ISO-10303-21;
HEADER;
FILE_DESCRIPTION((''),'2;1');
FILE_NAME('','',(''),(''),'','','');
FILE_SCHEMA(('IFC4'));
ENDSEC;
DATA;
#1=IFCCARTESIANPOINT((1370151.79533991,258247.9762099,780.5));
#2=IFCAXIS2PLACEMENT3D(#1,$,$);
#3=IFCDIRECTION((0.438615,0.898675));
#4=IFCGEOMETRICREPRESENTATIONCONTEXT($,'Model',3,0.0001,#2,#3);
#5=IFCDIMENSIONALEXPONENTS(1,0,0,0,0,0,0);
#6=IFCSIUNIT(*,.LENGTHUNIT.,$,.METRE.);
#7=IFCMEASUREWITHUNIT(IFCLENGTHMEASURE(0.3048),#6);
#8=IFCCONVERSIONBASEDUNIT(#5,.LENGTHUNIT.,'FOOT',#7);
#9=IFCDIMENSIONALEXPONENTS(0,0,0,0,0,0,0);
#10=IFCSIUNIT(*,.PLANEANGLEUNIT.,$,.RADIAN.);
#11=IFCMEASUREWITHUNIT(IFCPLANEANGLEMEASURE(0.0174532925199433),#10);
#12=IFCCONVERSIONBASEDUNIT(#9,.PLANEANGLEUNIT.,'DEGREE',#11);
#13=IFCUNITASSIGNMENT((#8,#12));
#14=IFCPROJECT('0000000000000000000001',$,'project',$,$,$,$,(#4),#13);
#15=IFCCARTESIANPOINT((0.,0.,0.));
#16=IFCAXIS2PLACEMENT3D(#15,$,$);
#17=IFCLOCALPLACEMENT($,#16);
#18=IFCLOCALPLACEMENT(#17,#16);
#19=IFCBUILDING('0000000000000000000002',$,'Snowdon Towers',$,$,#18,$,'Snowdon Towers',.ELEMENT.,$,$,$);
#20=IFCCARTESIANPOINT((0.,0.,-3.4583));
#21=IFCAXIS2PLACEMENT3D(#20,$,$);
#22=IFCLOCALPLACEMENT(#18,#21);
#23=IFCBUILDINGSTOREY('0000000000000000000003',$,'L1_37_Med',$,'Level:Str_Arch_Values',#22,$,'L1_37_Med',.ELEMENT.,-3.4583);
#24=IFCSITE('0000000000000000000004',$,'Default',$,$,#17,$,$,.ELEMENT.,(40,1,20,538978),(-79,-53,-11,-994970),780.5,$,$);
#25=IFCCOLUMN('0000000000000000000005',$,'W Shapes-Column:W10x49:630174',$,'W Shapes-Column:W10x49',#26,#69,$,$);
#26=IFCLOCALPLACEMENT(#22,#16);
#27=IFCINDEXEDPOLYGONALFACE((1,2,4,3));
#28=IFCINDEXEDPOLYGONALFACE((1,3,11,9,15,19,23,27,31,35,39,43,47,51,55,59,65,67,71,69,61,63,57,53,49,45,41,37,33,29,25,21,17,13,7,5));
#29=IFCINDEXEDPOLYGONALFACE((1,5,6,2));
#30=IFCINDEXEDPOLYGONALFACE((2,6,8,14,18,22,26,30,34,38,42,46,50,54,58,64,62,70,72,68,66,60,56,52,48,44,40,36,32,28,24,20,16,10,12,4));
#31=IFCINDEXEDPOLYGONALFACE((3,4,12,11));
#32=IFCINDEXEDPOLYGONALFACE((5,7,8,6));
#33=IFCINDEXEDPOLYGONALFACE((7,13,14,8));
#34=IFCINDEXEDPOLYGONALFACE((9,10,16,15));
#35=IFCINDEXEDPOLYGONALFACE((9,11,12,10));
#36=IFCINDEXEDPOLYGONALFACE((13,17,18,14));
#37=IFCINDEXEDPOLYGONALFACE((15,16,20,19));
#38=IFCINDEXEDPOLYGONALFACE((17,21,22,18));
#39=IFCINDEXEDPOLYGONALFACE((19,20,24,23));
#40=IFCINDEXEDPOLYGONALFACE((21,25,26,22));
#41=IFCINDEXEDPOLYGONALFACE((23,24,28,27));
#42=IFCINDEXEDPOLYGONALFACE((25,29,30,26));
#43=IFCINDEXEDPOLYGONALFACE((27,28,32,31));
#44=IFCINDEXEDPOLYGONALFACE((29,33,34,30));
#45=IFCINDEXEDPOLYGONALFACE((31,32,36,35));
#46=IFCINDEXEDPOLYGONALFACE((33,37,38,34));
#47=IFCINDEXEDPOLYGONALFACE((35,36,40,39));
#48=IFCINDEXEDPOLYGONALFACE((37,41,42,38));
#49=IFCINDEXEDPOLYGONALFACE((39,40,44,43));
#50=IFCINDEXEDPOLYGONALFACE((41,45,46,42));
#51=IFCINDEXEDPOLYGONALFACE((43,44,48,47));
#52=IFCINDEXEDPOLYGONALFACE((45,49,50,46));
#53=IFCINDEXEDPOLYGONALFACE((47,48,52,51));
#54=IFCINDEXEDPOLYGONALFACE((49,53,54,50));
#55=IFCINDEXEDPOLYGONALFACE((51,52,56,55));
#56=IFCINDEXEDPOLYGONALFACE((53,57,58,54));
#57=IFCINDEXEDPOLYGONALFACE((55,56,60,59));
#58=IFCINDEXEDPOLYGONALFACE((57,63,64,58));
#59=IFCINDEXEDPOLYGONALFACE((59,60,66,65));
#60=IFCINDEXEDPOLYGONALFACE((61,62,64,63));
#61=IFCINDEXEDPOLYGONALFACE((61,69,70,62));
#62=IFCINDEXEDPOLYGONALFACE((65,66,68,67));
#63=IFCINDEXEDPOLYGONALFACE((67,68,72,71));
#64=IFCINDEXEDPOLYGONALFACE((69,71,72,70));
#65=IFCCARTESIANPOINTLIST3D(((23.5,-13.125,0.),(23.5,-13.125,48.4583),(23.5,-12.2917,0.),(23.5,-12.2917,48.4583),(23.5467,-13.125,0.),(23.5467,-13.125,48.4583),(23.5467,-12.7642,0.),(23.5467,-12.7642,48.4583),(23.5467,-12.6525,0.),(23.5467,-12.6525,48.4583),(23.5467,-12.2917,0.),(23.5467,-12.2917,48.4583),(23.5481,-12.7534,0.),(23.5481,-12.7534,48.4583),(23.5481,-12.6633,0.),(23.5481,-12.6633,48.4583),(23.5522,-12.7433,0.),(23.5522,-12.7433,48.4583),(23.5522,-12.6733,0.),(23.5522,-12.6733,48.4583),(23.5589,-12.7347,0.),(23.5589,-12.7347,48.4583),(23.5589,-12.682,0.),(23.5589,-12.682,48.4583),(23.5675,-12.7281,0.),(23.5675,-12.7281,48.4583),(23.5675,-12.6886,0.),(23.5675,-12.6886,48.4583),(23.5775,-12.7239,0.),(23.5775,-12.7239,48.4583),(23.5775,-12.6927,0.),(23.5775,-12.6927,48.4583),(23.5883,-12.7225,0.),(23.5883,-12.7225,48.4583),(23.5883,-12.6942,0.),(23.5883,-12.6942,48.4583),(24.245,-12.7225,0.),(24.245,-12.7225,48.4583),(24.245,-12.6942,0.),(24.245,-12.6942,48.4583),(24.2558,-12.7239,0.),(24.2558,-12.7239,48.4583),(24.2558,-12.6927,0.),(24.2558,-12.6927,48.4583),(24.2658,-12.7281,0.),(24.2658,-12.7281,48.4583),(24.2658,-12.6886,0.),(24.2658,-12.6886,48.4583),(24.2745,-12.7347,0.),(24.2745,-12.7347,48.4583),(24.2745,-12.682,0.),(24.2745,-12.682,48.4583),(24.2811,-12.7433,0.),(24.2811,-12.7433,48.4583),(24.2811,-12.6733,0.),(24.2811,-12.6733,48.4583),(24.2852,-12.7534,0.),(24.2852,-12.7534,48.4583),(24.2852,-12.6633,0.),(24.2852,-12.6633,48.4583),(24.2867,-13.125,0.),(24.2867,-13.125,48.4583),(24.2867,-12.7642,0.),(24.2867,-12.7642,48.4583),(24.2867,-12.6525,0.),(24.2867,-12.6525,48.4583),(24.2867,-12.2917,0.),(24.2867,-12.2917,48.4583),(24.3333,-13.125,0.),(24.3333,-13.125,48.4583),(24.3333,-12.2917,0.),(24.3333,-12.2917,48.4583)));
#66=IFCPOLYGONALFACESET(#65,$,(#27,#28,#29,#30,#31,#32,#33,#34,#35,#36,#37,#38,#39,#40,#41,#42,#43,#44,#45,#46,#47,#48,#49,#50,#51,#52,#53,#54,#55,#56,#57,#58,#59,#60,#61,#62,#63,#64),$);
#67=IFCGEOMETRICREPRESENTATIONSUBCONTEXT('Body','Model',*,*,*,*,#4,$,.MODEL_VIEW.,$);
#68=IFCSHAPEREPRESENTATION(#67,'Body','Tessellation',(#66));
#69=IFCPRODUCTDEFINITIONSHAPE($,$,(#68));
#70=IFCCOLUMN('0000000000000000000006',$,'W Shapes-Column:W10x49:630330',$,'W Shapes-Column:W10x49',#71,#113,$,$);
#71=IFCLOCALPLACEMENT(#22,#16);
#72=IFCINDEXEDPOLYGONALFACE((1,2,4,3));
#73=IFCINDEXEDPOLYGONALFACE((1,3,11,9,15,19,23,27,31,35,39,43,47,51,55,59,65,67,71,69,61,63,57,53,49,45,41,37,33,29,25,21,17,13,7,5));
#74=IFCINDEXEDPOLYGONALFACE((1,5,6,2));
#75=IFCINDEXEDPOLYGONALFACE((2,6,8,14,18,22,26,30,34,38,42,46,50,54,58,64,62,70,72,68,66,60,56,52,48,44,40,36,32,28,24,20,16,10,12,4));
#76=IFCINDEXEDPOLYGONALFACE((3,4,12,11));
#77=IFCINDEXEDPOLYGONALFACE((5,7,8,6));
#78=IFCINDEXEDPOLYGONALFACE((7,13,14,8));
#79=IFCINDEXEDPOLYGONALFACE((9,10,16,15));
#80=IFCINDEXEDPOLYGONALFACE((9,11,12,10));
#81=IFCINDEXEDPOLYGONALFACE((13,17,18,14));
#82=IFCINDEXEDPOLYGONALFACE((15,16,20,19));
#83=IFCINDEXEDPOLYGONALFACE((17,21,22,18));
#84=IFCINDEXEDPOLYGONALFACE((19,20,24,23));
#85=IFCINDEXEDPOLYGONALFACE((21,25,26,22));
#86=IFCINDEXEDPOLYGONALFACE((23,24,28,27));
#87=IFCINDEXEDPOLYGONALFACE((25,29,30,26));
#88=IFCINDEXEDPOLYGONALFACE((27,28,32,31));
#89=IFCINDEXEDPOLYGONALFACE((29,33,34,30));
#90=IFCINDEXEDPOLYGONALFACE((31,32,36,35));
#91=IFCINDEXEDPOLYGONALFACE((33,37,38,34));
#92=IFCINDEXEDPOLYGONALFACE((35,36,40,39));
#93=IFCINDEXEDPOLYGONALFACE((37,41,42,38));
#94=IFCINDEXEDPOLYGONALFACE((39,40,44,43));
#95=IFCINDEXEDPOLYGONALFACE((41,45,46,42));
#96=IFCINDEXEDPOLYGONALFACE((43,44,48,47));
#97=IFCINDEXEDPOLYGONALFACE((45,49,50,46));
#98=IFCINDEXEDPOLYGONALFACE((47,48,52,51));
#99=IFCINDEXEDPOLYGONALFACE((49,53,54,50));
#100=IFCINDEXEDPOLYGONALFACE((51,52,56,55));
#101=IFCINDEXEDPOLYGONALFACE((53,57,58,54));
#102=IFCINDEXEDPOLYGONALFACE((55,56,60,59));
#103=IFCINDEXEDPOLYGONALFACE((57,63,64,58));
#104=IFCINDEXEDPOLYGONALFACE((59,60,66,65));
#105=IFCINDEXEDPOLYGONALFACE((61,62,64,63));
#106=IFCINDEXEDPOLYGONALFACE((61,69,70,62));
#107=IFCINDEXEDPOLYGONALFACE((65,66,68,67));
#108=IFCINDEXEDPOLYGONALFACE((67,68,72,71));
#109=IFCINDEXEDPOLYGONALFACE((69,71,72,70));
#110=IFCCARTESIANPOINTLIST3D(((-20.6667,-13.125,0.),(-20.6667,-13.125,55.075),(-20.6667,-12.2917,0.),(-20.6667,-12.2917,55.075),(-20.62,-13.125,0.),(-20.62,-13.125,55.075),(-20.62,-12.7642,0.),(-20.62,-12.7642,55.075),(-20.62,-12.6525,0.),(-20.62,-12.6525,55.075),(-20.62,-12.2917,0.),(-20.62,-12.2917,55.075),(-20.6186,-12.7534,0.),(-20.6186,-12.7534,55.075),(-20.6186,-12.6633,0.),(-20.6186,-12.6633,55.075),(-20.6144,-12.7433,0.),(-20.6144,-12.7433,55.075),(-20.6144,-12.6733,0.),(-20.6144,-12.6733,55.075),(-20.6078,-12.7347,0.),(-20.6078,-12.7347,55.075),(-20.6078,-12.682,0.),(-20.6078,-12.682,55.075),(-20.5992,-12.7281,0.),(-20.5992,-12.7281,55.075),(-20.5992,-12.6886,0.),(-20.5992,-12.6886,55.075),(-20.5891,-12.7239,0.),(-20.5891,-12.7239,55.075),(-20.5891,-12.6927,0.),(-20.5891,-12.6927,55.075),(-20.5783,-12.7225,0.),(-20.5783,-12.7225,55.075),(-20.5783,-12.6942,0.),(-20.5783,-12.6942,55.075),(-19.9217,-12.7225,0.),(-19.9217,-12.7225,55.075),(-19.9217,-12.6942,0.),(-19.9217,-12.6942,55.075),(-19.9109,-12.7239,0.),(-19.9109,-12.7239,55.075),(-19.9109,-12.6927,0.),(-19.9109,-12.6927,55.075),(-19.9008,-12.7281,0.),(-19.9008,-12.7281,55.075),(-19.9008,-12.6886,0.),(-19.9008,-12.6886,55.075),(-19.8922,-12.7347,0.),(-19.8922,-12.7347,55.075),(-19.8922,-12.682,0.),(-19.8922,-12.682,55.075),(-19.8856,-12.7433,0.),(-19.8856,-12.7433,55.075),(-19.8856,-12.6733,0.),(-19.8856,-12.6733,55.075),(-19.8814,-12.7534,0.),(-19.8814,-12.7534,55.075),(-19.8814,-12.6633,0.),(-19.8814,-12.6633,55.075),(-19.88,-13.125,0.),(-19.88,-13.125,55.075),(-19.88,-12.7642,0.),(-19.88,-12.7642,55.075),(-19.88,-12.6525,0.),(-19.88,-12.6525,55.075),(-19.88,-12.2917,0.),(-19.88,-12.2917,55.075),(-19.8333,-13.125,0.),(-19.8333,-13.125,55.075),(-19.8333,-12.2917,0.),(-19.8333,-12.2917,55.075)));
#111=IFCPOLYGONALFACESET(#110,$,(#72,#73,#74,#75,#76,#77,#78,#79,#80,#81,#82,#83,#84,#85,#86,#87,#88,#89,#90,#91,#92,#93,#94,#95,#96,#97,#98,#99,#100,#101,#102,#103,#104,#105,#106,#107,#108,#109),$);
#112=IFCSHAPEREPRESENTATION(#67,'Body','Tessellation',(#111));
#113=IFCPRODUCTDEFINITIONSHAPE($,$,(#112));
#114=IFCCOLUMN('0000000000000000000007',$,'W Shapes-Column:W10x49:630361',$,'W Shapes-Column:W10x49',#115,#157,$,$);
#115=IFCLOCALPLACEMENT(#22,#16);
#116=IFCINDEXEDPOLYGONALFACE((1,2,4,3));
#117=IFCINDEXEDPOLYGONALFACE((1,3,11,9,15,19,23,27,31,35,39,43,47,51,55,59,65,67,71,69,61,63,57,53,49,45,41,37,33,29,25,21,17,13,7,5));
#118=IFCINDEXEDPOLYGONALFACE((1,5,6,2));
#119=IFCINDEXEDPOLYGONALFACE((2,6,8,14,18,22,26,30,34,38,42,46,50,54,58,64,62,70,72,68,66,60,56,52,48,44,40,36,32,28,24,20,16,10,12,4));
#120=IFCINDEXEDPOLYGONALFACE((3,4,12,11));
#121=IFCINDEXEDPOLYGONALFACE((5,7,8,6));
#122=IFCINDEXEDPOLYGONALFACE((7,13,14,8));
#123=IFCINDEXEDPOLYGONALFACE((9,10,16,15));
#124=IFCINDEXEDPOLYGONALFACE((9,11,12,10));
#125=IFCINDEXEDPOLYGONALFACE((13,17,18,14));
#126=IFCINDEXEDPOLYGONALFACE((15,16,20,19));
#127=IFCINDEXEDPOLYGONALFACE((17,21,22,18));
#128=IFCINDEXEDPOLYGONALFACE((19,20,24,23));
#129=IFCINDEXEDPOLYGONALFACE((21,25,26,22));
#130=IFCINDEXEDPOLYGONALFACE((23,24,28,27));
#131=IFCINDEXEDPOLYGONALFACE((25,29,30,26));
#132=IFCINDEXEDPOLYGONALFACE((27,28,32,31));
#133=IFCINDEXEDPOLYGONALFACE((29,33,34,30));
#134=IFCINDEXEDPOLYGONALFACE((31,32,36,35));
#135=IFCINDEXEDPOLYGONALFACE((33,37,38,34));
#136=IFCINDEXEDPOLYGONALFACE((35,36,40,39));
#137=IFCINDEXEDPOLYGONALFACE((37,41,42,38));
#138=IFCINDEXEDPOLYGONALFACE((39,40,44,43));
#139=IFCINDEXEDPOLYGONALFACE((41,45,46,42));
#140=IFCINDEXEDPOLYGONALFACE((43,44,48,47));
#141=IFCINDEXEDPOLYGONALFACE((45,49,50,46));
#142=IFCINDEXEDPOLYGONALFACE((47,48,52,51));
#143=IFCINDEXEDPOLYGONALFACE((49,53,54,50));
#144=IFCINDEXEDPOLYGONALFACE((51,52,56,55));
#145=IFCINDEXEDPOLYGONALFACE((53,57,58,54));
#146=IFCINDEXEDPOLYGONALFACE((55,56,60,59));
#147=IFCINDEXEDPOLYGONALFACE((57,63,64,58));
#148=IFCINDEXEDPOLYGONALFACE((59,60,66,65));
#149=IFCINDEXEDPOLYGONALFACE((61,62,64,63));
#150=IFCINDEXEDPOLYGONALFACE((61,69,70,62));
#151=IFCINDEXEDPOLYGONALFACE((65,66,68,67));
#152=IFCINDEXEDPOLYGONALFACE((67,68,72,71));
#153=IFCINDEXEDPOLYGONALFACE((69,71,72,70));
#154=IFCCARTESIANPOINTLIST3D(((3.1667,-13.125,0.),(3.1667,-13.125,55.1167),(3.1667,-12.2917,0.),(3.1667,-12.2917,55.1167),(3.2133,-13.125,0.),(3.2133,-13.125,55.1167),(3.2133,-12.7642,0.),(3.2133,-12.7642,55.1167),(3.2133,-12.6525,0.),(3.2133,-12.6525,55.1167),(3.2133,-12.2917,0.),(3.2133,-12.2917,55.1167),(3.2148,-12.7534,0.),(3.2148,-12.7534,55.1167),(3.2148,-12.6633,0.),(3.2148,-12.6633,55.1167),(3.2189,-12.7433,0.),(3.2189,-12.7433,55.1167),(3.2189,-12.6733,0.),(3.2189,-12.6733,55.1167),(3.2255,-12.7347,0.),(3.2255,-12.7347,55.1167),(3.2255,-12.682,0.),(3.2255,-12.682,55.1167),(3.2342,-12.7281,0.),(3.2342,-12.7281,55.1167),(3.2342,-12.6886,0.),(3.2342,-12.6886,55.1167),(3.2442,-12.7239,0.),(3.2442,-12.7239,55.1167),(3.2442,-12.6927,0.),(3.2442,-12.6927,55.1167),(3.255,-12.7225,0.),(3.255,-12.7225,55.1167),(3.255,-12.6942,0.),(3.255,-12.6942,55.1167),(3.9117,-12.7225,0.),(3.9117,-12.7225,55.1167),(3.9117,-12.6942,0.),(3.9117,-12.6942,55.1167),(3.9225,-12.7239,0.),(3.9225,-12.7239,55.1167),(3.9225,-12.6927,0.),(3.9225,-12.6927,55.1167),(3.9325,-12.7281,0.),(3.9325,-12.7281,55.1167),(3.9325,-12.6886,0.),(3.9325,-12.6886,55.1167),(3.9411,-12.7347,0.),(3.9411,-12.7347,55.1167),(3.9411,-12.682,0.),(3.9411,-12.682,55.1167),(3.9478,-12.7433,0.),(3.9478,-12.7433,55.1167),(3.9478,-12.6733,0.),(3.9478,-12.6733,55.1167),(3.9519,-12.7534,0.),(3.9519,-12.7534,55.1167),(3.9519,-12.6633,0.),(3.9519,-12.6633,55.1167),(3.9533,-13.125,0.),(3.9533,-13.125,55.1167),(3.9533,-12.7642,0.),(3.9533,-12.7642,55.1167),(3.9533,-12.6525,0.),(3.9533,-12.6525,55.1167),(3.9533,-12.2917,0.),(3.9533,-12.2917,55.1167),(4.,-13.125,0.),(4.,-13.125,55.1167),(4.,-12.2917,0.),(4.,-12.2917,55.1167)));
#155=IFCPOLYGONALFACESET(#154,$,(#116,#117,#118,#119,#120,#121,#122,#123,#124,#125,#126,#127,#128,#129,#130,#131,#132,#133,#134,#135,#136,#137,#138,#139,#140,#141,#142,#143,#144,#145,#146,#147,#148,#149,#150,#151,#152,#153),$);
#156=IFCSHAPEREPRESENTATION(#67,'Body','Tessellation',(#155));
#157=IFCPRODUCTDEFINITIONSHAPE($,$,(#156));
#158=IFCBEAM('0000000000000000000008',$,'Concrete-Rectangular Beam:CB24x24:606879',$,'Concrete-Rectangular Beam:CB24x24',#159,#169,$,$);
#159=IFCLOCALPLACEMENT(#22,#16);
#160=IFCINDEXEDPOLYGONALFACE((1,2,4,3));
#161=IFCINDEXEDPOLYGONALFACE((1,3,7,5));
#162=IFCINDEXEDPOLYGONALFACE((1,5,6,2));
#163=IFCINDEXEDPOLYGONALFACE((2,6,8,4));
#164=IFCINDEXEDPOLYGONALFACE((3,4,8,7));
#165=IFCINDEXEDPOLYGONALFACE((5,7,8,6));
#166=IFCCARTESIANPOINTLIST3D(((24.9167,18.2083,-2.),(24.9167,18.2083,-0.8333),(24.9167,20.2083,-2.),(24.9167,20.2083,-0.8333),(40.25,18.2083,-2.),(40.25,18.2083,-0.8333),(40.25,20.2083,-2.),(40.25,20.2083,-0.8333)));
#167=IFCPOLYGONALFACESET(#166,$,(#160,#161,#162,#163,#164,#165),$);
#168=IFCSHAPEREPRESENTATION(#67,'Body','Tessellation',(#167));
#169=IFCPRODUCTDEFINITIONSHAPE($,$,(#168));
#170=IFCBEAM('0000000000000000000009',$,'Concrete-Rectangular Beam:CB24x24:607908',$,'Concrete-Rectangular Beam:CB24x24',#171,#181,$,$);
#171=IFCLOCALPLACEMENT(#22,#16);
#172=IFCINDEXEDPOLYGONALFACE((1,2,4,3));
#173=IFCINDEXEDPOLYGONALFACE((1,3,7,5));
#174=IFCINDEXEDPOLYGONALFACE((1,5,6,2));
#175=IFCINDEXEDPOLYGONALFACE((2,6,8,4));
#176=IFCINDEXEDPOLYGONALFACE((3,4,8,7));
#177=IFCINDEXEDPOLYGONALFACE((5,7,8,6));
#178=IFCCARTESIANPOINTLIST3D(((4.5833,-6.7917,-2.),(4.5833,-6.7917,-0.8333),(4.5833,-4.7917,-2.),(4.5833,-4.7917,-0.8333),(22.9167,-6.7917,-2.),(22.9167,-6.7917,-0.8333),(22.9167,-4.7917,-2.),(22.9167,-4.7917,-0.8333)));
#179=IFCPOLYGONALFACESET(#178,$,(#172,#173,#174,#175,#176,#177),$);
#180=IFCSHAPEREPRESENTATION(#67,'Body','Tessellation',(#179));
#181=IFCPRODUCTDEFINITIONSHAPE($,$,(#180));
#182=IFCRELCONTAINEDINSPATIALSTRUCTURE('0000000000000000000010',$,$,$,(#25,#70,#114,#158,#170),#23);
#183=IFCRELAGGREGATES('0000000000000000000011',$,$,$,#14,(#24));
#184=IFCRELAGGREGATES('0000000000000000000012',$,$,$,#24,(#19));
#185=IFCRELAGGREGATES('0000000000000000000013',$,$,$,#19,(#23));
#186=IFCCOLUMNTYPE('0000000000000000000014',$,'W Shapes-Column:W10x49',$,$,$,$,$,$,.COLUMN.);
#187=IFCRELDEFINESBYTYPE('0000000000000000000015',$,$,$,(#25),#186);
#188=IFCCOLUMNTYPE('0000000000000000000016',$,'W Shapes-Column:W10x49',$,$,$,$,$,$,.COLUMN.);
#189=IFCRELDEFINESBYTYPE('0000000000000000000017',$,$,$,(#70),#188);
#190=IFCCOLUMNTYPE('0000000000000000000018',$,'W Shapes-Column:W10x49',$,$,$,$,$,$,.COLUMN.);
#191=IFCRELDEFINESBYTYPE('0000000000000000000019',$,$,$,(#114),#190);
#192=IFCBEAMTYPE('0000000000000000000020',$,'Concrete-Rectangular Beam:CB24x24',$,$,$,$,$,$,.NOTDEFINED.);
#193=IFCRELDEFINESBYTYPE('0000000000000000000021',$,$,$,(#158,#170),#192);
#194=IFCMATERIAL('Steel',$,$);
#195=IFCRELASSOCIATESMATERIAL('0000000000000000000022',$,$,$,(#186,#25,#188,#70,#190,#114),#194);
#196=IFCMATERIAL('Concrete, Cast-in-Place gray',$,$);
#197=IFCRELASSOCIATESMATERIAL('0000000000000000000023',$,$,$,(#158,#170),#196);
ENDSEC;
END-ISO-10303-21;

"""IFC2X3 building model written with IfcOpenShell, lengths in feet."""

from ifc_helpers import new_model, entity, si_unit, converted_unit, direction, frame, frame_2d, origin, place, context, subcontext, project, spatial, rectangle, i_section, extrude, source, transform, mapped, material, type_object, type_shapes, element, save


model = new_model("IFC2X3")

# Units and contexts
model_context = context("Model", 3, precision=0.0001, world=frame((1370151.79533991, 258247.9762099, 780.5)), true_north=direction((0.438615, 0.898675)))
body_context = subcontext(model_context, "Body", "Model", "MODEL_VIEW")
ifc_project = project(units=[converted_unit("LENGTHUNIT", "FOOT", entity("IfcLengthMeasure", 0.3048), si_unit("LENGTHUNIT", "METRE"), dimensions=[1, 0, 0, 0, 0, 0, 0]), converted_unit("PLANEANGLEUNIT", "DEGREE", entity("IfcPlaneAngleMeasure", 0.0174532925199433), si_unit("PLANEANGLEUNIT", "RADIAN"), dimensions=[0, 0, 0, 0, 0, 0, 0])], contexts=[model_context])

# Site, building, storey
site_placement = place(None, origin())
site = spatial("IfcSite", under=ifc_project, at=site_placement, Name="Default", CompositionType="ELEMENT", RefLatitude=(40, 1, 20, 538978), RefLongitude=(-79, -53, -11, -994970), RefElevation=780.5)
building_placement = place(site_placement, origin())
building = spatial("IfcBuilding", under=site, at=building_placement, Name="Snowdon Towers", LongName="Snowdon Towers", CompositionType="ELEMENT")
storey_placement = place(building_placement, frame((0.0, 0.0, -3.4583)))
storey = spatial("IfcBuildingStorey", under=building, at=storey_placement, Name="L1_37_Med", ObjectType="Level:Str_Arch_Values", LongName="L1_37_Med", CompositionType="ELEMENT", Elevation=-3.4583)

# Columns
ifc_material_1 = material(Name="Steel")
column_type_1 = type_object("IfcColumnType", Name="W Shapes-Column:W10x49", PredefinedType="COLUMN", material=ifc_material_1)
shared_shape_1 = source(origin(), body_context, "Body", "SweptSolid", [
    extrude(i_section(OverallWidth=0.8333, OverallDepth=0.8333, WebThickness=0.0283, FlangeThickness=0.0467, FilletRadius=0.0417, at=frame_2d((0.0, 0.0), x_axis=(1.0, 0.0))), frame((0.0, 0.0, -3.4583), z_axis=(0.0, 0.0, 1.0), x_axis=(-1.0, 0.0, 0.0)), (0.0, 0.0, 1.0), 48.4583),
])
type_shapes(column_type_1, [shared_shape_1])
column_1_placement = place(storey_placement, frame((23.9167, -12.7083, 3.4583), z_axis=(0.0, 0.0, 1.0), x_axis=(0.0, 1.0, 0.0)))
element("IfcColumn", 1, at=column_1_placement, inside=storey, type_object=column_type_1, material=ifc_material_1, Name="W Shapes-Column:W10x49:630174", ObjectType="W Shapes-Column:W10x49", context=body_context, shape_type="MappedRepresentation", body=[
    mapped(shared_shape_1, transform((0.0, 0.0, 0.0), scale=1.0)),
])
column_type_2 = type_object("IfcColumnType", Name="W Shapes-Column:W10x49", PredefinedType="COLUMN", material=ifc_material_1)
shared_shape_2 = source(origin(), body_context, "Body", "SweptSolid", [
    extrude(i_section(OverallWidth=0.8333, OverallDepth=0.8333, WebThickness=0.0283, FlangeThickness=0.0467, FilletRadius=0.0417, at=frame_2d((0.0, 0.0), x_axis=(1.0, 0.0))), frame((-20.25, -12.7083, -3.4583), z_axis=(0.0, 0.0, 1.0), x_axis=(0.0, -1.0, 0.0)), (0.0, 0.0, 1.0), 55.075),
])
type_shapes(column_type_2, [shared_shape_2])
column_2_placement = place(storey_placement, frame((0.0, 0.0, 3.4583)))
element("IfcColumn", 2, at=column_2_placement, inside=storey, type_object=column_type_2, material=ifc_material_1, Name="W Shapes-Column:W10x49:630330", ObjectType="W Shapes-Column:W10x49", context=body_context, shape_type="MappedRepresentation", body=[
    mapped(shared_shape_2, transform((0.0, 0.0, 0.0), scale=1.0)),
])
column_type_3 = type_object("IfcColumnType", Name="W Shapes-Column:W10x49", PredefinedType="COLUMN", material=ifc_material_1)
shared_shape_3 = source(origin(), body_context, "Body", "SweptSolid", [
    extrude(i_section(OverallWidth=0.8333, OverallDepth=0.8333, WebThickness=0.0283, FlangeThickness=0.0467, FilletRadius=0.0417, at=frame_2d((0.0, 0.0), x_axis=(1.0, 0.0))), frame((3.5833, -12.7083, -3.4583), z_axis=(0.0, 0.0, 1.0), x_axis=(0.0, -1.0, 0.0)), (0.0, 0.0, 1.0), 55.1167),
])
type_shapes(column_type_3, [shared_shape_3])
column_3_placement = place(storey_placement, frame((0.0, 0.0, 3.4583)))
element("IfcColumn", 3, at=column_3_placement, inside=storey, type_object=column_type_3, material=ifc_material_1, Name="W Shapes-Column:W10x49:630361", ObjectType="W Shapes-Column:W10x49", context=body_context, shape_type="MappedRepresentation", body=[
    mapped(shared_shape_3, transform((0.0, 0.0, 0.0), scale=1.0)),
])

# Beams
ifc_material_2 = material(Name="Concrete, Cast-in-Place gray")
beam_type_1 = type_object("IfcBeamType", Name="Concrete-Rectangular Beam:CB24x24", PredefinedType="NOTDEFINED")
beam_1_placement = place(storey_placement, frame((23.9167, 19.2083, 0.0)))
element("IfcBeam", 4, at=beam_1_placement, inside=storey, type_object=beam_type_1, material=ifc_material_2, Name="Concrete-Rectangular Beam:CB24x24:606879", ObjectType="Concrete-Rectangular Beam:CB24x24", context=body_context, shape_type="SweptSolid", body=[
    extrude(rectangle(XDim=1.1667, YDim=2.0, at=frame_2d((0.0, 0.0), x_axis=(1.0, 0.0))), frame((1.0, 0.0, -1.4167), z_axis=(1.0, 0.0, 0.0), x_axis=(0.0, 0.0, -1.0)), (0.0, 0.0, 1.0), 15.3333),
])
beam_2_placement = place(storey_placement, frame((3.75, -5.7917, 0.0)))
element("IfcBeam", 5, at=beam_2_placement, inside=storey, type_object=beam_type_1, material=ifc_material_2, Name="Concrete-Rectangular Beam:CB24x24:607908", ObjectType="Concrete-Rectangular Beam:CB24x24", context=body_context, shape_type="SweptSolid", body=[
    extrude(rectangle(XDim=1.1667, YDim=2.0, at=frame_2d((0.0, 0.0), x_axis=(1.0, 0.0))), frame((0.8333, 0.0, -1.4167), z_axis=(1.0, 0.0, 0.0), x_axis=(0.0, 0.0, -1.0)), (0.0, 0.0, 1.0), 18.3333),
])

save(model, "model.ifc")
